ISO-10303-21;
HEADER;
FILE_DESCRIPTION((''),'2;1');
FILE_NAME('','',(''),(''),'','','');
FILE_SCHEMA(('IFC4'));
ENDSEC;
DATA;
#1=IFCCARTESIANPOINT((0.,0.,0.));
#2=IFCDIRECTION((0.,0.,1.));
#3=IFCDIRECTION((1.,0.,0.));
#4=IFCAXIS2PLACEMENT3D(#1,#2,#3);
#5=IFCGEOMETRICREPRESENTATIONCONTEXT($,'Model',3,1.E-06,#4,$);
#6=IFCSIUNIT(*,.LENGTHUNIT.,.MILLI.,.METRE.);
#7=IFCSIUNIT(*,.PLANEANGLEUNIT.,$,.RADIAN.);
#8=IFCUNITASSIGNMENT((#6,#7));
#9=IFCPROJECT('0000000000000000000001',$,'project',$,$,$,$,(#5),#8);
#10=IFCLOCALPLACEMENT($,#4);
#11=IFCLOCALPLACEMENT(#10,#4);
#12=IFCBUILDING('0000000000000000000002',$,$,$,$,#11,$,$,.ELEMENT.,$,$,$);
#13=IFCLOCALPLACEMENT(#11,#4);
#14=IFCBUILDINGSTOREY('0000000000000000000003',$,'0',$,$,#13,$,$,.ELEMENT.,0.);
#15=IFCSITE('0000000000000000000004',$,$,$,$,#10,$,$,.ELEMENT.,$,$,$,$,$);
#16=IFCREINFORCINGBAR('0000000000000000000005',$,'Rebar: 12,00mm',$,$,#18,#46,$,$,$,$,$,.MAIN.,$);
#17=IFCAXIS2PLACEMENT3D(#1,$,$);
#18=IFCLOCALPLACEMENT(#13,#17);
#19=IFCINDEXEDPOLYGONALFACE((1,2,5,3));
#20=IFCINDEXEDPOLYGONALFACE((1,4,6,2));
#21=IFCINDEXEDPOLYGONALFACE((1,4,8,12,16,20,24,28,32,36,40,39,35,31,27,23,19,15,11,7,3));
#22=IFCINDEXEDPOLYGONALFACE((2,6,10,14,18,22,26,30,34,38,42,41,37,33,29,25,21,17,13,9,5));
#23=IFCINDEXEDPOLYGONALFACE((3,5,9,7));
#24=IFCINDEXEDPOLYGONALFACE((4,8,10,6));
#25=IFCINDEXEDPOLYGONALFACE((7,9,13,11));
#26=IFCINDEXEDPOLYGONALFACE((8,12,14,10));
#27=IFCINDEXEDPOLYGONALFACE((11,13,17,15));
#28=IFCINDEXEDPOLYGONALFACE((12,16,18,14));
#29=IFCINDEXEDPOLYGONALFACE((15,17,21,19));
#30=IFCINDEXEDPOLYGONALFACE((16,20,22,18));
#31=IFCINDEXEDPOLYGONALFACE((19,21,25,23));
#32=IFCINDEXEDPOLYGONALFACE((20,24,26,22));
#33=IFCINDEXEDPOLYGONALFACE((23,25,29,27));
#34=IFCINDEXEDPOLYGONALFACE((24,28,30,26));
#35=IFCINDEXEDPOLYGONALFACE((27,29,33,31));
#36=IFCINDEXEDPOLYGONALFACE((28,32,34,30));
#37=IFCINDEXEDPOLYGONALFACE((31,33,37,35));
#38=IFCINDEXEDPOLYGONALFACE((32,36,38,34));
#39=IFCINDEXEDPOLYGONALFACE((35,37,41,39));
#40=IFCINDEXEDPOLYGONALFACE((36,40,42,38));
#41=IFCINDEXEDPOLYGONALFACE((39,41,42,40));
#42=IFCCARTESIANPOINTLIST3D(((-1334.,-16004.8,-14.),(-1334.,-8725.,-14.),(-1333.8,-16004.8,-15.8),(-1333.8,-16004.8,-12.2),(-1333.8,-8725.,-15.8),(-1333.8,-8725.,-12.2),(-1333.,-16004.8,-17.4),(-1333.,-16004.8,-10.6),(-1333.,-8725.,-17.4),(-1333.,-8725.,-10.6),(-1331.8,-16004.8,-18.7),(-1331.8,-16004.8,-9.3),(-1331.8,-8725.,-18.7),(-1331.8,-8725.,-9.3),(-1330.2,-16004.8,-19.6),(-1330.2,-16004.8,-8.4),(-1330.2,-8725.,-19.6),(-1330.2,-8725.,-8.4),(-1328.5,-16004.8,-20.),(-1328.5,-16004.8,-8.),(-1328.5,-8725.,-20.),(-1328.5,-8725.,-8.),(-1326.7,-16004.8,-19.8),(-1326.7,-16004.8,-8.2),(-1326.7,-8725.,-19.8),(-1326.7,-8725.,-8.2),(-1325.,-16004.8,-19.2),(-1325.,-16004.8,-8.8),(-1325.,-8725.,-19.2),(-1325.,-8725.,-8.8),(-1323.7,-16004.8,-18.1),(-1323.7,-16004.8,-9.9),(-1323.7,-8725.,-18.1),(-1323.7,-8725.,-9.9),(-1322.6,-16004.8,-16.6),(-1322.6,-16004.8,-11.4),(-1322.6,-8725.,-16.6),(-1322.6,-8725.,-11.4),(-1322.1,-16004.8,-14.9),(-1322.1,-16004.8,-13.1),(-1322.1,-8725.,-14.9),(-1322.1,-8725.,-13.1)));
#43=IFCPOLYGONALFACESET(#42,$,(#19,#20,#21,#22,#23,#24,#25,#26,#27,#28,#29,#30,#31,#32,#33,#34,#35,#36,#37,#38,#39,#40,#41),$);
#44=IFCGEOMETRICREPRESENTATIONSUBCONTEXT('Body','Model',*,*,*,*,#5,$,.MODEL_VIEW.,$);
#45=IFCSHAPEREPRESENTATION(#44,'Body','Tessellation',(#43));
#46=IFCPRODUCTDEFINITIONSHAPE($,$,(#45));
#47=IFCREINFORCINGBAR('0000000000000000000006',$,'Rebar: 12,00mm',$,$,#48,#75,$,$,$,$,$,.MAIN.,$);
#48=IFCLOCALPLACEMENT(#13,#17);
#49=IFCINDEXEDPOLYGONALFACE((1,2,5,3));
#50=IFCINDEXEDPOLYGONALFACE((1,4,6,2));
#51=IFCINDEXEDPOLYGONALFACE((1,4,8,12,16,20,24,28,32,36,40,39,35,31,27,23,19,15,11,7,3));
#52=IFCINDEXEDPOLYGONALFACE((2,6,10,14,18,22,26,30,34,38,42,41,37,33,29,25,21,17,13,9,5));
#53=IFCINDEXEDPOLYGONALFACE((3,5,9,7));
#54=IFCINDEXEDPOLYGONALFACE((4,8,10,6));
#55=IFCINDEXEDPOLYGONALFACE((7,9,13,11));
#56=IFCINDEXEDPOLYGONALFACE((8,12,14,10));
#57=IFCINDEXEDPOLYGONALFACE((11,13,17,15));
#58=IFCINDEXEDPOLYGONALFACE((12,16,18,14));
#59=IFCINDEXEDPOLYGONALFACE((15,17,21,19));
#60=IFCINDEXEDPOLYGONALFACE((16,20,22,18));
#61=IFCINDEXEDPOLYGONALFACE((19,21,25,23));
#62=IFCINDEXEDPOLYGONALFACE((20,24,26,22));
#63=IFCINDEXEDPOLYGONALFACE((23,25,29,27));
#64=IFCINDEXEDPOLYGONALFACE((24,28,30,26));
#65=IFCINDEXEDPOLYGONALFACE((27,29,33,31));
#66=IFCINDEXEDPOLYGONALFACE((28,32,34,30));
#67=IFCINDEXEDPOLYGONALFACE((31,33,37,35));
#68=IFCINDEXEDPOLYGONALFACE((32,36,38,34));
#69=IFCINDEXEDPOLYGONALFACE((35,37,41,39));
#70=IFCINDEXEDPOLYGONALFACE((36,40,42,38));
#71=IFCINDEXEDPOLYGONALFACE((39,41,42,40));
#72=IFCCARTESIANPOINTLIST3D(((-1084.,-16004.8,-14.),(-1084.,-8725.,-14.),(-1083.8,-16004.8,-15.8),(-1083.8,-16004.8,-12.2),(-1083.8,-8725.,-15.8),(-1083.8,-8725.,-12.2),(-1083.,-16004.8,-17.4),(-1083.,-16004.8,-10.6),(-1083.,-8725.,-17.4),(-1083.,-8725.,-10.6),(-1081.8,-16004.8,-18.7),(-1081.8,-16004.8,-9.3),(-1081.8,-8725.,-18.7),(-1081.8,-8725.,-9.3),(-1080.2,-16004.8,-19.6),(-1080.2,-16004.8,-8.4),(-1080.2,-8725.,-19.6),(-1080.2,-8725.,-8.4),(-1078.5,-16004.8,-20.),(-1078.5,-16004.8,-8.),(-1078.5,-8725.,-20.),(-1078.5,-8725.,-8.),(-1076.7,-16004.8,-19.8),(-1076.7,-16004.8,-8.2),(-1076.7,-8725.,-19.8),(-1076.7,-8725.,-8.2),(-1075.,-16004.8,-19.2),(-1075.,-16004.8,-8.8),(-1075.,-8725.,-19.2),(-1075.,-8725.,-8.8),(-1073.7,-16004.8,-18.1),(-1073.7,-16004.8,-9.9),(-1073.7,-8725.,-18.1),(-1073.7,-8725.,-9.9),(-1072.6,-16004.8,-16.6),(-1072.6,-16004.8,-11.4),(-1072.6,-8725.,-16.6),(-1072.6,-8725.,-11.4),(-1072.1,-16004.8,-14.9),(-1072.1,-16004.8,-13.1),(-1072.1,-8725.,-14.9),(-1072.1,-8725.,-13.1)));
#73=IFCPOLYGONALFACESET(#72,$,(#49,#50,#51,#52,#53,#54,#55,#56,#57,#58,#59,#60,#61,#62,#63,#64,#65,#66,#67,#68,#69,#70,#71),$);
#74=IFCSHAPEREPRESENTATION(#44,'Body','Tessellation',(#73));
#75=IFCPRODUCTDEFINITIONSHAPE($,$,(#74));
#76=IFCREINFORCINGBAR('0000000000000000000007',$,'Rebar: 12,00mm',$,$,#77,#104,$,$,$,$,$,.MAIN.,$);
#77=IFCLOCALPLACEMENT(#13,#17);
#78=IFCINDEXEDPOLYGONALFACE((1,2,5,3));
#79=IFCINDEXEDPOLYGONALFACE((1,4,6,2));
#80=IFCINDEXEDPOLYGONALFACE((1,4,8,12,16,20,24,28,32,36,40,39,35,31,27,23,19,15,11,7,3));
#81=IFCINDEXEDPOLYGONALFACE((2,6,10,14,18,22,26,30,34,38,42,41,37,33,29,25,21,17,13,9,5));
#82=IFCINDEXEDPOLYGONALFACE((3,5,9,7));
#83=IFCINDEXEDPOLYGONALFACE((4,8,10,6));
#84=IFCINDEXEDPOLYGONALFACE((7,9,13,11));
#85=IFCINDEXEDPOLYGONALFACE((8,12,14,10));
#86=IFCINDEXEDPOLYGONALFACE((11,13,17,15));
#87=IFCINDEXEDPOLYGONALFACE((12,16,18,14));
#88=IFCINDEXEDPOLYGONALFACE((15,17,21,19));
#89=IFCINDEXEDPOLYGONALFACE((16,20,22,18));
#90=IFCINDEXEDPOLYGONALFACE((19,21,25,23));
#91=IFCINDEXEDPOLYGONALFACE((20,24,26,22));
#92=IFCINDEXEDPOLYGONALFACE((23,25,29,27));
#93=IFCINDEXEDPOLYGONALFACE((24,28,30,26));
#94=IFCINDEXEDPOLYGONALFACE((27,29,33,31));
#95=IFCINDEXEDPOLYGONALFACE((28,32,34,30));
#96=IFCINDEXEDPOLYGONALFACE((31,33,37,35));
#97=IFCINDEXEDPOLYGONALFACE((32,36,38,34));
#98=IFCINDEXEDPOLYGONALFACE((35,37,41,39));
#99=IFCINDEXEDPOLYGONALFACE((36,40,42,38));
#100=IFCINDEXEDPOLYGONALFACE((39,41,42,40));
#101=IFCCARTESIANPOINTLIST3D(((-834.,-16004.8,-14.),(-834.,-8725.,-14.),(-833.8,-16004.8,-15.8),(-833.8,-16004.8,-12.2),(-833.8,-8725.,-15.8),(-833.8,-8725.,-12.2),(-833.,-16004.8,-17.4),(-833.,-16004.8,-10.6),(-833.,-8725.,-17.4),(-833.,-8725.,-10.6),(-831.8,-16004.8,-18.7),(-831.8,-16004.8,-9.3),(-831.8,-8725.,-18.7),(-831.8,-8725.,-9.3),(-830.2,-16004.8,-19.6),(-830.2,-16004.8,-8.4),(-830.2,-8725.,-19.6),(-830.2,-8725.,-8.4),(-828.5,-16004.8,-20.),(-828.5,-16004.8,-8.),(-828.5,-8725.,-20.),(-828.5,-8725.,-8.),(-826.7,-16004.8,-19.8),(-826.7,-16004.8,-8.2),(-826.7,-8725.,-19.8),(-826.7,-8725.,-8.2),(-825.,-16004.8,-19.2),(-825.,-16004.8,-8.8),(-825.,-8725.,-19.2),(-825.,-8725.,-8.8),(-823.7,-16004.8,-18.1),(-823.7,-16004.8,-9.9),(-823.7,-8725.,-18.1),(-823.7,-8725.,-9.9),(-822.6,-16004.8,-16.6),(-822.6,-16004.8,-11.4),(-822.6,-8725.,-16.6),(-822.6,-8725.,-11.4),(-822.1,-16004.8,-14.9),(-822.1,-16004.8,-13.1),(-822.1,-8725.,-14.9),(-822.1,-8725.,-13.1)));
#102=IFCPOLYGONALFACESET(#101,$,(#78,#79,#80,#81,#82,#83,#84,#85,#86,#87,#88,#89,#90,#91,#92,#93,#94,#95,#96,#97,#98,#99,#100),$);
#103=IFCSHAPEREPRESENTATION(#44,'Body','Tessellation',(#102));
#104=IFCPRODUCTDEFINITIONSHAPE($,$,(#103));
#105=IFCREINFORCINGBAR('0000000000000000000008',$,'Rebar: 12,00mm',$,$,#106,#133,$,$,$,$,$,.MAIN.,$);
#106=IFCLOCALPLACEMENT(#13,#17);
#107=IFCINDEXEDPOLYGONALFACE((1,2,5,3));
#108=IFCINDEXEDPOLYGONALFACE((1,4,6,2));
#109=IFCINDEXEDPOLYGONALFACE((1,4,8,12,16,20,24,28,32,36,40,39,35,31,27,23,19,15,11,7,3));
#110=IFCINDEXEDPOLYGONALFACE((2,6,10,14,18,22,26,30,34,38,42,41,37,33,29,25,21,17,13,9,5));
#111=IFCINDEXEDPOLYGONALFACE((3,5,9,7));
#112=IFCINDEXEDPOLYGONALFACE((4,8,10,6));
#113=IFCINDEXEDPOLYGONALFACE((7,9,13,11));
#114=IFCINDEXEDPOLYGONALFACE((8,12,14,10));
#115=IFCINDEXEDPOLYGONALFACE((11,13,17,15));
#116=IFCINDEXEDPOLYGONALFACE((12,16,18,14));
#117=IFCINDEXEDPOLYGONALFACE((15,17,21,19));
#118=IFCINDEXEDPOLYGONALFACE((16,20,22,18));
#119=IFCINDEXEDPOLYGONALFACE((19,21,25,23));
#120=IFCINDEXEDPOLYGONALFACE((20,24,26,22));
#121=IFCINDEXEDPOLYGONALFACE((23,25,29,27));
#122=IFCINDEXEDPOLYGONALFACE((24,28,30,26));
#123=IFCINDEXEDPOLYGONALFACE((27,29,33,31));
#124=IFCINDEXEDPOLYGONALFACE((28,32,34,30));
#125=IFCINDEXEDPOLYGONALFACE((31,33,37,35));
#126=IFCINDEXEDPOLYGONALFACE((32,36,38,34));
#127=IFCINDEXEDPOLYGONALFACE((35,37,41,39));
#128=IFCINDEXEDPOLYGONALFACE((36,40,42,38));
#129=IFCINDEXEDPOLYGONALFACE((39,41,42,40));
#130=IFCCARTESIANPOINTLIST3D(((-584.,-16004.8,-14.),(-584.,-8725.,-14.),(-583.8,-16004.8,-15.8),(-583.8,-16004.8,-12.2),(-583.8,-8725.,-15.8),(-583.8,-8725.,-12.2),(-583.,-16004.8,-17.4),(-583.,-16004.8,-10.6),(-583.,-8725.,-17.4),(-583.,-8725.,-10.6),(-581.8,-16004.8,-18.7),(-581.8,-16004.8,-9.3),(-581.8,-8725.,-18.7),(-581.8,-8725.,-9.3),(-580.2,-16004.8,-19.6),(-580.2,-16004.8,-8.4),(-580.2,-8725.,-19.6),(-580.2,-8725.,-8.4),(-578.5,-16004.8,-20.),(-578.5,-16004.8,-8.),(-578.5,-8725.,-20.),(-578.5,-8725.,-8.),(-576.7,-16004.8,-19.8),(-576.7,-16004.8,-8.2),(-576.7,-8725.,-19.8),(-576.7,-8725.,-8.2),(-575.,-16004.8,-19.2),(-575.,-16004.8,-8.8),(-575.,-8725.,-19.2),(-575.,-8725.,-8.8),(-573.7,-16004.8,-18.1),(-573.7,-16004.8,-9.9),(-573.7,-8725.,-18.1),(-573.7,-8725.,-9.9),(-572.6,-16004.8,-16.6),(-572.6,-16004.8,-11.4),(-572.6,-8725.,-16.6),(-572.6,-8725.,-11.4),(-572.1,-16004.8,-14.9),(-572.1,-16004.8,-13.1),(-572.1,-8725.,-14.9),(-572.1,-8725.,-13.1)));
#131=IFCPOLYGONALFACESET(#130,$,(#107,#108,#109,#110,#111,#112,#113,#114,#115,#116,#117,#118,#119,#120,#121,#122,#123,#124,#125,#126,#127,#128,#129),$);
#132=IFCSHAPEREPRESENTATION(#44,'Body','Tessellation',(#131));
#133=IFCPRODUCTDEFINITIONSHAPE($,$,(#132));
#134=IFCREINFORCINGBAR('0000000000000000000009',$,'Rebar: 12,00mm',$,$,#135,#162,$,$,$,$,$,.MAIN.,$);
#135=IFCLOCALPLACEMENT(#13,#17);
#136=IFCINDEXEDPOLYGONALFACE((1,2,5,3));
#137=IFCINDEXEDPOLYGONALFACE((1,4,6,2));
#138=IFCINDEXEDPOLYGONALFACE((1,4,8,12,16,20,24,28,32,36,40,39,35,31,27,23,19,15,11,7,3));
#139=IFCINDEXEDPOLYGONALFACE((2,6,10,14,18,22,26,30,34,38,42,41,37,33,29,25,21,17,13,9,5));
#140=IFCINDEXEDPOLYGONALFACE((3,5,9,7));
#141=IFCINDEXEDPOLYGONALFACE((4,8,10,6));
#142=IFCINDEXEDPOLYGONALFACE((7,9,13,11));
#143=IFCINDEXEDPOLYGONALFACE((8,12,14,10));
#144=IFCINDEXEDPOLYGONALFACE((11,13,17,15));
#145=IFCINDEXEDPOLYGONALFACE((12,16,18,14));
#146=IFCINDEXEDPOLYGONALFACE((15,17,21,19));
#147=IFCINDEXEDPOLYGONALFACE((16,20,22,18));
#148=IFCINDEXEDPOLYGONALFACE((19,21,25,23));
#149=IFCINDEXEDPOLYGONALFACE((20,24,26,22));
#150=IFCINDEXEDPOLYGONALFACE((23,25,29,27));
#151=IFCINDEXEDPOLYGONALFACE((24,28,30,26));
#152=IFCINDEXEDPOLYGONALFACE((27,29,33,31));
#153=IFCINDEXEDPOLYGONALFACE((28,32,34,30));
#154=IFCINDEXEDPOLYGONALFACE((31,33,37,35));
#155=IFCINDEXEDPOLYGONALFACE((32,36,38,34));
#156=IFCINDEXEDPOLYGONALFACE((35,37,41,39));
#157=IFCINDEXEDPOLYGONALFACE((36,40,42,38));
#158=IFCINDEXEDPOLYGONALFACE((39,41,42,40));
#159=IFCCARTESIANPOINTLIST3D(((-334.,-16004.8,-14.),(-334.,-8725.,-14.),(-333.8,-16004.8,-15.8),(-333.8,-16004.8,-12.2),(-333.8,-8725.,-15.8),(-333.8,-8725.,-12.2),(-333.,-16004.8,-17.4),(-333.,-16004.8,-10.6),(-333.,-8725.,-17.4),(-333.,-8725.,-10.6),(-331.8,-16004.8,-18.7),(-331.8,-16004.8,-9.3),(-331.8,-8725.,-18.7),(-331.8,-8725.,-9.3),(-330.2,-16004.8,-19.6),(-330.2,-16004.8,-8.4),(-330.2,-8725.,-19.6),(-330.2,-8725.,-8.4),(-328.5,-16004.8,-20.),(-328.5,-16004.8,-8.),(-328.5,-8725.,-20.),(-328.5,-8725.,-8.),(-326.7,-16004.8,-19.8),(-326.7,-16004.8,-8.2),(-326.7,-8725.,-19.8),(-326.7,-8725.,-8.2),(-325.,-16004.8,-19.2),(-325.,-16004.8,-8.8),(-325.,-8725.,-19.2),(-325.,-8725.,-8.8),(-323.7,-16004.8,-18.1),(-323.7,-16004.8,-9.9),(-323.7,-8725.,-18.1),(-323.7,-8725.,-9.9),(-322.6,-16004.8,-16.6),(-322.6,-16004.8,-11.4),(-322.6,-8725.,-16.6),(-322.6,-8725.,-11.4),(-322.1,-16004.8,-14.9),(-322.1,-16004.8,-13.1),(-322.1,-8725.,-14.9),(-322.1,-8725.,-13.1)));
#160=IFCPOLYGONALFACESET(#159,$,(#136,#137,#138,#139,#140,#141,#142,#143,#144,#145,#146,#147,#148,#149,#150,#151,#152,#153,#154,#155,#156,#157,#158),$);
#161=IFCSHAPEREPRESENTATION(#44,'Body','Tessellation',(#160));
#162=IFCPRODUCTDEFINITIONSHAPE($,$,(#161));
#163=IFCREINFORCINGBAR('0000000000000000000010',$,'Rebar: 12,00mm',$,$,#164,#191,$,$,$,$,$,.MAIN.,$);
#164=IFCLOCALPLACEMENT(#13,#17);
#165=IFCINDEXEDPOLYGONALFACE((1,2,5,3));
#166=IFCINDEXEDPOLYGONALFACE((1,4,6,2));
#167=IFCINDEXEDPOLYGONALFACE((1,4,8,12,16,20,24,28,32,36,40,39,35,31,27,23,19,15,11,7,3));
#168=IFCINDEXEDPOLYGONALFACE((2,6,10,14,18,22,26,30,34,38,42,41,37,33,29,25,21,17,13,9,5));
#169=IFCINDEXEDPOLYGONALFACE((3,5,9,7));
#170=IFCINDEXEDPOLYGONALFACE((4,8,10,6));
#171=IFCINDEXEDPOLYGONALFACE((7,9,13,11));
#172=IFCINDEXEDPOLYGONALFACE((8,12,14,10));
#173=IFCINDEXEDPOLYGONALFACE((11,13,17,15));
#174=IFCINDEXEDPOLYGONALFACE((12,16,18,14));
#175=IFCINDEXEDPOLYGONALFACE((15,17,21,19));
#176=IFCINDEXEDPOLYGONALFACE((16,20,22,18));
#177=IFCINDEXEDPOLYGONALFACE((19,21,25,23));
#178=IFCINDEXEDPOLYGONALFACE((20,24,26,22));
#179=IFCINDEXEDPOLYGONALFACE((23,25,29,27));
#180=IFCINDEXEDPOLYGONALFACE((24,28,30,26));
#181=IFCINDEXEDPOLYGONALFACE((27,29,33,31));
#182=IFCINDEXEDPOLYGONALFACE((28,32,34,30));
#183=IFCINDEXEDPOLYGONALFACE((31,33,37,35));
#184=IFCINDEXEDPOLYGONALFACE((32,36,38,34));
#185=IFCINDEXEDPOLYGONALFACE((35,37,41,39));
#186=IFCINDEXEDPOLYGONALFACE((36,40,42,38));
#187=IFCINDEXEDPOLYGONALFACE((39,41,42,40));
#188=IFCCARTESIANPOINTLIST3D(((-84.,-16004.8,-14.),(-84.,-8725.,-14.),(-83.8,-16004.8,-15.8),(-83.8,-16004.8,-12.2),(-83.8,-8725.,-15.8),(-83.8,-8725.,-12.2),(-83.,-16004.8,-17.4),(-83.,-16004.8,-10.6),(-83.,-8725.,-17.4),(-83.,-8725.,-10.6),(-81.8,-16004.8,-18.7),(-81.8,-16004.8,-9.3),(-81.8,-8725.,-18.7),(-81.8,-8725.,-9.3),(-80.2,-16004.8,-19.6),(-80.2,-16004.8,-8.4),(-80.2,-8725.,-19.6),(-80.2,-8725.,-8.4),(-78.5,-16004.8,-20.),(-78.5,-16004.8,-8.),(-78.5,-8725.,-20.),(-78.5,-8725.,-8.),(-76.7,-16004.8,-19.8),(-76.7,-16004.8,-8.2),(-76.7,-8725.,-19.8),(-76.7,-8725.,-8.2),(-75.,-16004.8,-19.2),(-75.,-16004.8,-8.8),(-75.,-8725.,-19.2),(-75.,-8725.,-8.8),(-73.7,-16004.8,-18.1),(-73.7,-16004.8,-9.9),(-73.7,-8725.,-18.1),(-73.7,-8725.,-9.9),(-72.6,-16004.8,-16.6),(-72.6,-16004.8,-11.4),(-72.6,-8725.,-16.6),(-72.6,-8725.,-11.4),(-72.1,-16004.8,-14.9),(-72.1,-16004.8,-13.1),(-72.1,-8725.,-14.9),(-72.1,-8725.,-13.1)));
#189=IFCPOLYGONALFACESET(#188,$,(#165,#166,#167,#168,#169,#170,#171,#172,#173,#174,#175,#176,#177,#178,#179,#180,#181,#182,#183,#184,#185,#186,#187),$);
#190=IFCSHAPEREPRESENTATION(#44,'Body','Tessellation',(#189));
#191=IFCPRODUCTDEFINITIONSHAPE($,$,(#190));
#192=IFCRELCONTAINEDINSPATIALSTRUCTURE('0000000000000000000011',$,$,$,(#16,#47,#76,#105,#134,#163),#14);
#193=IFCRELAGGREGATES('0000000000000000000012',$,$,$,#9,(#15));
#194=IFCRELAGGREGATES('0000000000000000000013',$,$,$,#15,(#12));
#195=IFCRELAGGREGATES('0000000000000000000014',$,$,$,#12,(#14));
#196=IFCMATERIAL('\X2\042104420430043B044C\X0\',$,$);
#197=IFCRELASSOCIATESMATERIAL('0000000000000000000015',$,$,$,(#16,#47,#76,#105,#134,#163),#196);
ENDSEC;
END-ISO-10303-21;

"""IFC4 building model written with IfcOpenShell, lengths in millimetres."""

from ifc_helpers import new_model, entity, si_unit, origin_with_axes, place, context, subcontext, project, spatial, source, transform, mapped, material, element, save


model = new_model("IFC4")

# Units and contexts
model_context = context("Model", 3, precision=1e-06, world=origin_with_axes())
body_context = subcontext(model_context, "Body", "Model", "MODEL_VIEW")
ifc_project = project(units=[si_unit("LENGTHUNIT", "METRE", prefix="MILLI"), si_unit("PLANEANGLEUNIT", "RADIAN")], contexts=[model_context])

# Site, building, storey
site_placement = place(None, origin_with_axes())
site = spatial("IfcSite", under=ifc_project, at=site_placement, CompositionType="ELEMENT")
building_placement = place(site_placement, origin_with_axes())
building = spatial("IfcBuilding", under=site, at=building_placement, CompositionType="ELEMENT")
storey_placement = place(building_placement, origin_with_axes())
storey = spatial("IfcBuildingStorey", under=building, at=storey_placement, Name="0", CompositionType="ELEMENT", Elevation=0.0)

# Reinforcing bars
ifc_material = material(Name="Сталь")
shared_shape = source(origin_with_axes(), body_context, "Body", "AdvancedSweptSolid", [
    entity("IfcSweptDiskSolid", entity("IfcIndexedPolyCurve", entity("IfcCartesianPointList3D", [[0.0, 0.0, 0.0], [7279.8, 0.0, 0.0]]), [entity("IfcLineIndex", [1, 2])]), 6.0),
])
reinforcing_bar_1_placement = place(storey_placement, origin_with_axes())
element("IfcReinforcingBar", 1, at=reinforcing_bar_1_placement, inside=storey, material=ifc_material, Name="Rebar: 12,00mm", PredefinedType="MAIN", context=body_context, shape_type="MappedRepresentation", body=[
    mapped(shared_shape, transform((-1328.0, -16004.8, -14.0), x_axis=(0.0, 1.0, 0.0), y_axis=(-1.0, 0.0, 0.0), z_axis=(0.0, 0.0, 1.0), scale=1.0)),
])
reinforcing_bar_2_placement = place(storey_placement, origin_with_axes())
element("IfcReinforcingBar", 2, at=reinforcing_bar_2_placement, inside=storey, material=ifc_material, Name="Rebar: 12,00mm", PredefinedType="MAIN", context=body_context, shape_type="MappedRepresentation", body=[
    mapped(shared_shape, transform((-1078.0, -16004.8, -14.0), x_axis=(0.0, 1.0, 0.0), y_axis=(-1.0, 0.0, 0.0), z_axis=(0.0, 0.0, 1.0), scale=1.0)),
])
reinforcing_bar_3_placement = place(storey_placement, origin_with_axes())
element("IfcReinforcingBar", 3, at=reinforcing_bar_3_placement, inside=storey, material=ifc_material, Name="Rebar: 12,00mm", PredefinedType="MAIN", context=body_context, shape_type="MappedRepresentation", body=[
    mapped(shared_shape, transform((-828.0, -16004.8, -14.0), x_axis=(0.0, 1.0, 0.0), y_axis=(-1.0, 0.0, 0.0), z_axis=(0.0, 0.0, 1.0), scale=1.0)),
])
reinforcing_bar_4_placement = place(storey_placement, origin_with_axes())
element("IfcReinforcingBar", 4, at=reinforcing_bar_4_placement, inside=storey, material=ifc_material, Name="Rebar: 12,00mm", PredefinedType="MAIN", context=body_context, shape_type="MappedRepresentation", body=[
    mapped(shared_shape, transform((-578.0, -16004.8, -14.0), x_axis=(0.0, 1.0, 0.0), y_axis=(-1.0, 0.0, 0.0), z_axis=(0.0, 0.0, 1.0), scale=1.0)),
])
reinforcing_bar_5_placement = place(storey_placement, origin_with_axes())
element("IfcReinforcingBar", 5, at=reinforcing_bar_5_placement, inside=storey, material=ifc_material, Name="Rebar: 12,00mm", PredefinedType="MAIN", context=body_context, shape_type="MappedRepresentation", body=[
    mapped(shared_shape, transform((-328.0, -16004.8, -14.0), x_axis=(0.0, 1.0, 0.0), y_axis=(-1.0, 0.0, 0.0), z_axis=(0.0, 0.0, 1.0), scale=1.0)),
])
reinforcing_bar_6_placement = place(storey_placement, origin_with_axes())
element("IfcReinforcingBar", 6, at=reinforcing_bar_6_placement, inside=storey, material=ifc_material, Name="Rebar: 12,00mm", PredefinedType="MAIN", context=body_context, shape_type="MappedRepresentation", body=[
    mapped(shared_shape, transform((-78.0, -16004.8, -14.0), x_axis=(0.0, 1.0, 0.0), y_axis=(-1.0, 0.0, 0.0), z_axis=(0.0, 0.0, 1.0), scale=1.0)),
])

save(model, "model.ifc")
